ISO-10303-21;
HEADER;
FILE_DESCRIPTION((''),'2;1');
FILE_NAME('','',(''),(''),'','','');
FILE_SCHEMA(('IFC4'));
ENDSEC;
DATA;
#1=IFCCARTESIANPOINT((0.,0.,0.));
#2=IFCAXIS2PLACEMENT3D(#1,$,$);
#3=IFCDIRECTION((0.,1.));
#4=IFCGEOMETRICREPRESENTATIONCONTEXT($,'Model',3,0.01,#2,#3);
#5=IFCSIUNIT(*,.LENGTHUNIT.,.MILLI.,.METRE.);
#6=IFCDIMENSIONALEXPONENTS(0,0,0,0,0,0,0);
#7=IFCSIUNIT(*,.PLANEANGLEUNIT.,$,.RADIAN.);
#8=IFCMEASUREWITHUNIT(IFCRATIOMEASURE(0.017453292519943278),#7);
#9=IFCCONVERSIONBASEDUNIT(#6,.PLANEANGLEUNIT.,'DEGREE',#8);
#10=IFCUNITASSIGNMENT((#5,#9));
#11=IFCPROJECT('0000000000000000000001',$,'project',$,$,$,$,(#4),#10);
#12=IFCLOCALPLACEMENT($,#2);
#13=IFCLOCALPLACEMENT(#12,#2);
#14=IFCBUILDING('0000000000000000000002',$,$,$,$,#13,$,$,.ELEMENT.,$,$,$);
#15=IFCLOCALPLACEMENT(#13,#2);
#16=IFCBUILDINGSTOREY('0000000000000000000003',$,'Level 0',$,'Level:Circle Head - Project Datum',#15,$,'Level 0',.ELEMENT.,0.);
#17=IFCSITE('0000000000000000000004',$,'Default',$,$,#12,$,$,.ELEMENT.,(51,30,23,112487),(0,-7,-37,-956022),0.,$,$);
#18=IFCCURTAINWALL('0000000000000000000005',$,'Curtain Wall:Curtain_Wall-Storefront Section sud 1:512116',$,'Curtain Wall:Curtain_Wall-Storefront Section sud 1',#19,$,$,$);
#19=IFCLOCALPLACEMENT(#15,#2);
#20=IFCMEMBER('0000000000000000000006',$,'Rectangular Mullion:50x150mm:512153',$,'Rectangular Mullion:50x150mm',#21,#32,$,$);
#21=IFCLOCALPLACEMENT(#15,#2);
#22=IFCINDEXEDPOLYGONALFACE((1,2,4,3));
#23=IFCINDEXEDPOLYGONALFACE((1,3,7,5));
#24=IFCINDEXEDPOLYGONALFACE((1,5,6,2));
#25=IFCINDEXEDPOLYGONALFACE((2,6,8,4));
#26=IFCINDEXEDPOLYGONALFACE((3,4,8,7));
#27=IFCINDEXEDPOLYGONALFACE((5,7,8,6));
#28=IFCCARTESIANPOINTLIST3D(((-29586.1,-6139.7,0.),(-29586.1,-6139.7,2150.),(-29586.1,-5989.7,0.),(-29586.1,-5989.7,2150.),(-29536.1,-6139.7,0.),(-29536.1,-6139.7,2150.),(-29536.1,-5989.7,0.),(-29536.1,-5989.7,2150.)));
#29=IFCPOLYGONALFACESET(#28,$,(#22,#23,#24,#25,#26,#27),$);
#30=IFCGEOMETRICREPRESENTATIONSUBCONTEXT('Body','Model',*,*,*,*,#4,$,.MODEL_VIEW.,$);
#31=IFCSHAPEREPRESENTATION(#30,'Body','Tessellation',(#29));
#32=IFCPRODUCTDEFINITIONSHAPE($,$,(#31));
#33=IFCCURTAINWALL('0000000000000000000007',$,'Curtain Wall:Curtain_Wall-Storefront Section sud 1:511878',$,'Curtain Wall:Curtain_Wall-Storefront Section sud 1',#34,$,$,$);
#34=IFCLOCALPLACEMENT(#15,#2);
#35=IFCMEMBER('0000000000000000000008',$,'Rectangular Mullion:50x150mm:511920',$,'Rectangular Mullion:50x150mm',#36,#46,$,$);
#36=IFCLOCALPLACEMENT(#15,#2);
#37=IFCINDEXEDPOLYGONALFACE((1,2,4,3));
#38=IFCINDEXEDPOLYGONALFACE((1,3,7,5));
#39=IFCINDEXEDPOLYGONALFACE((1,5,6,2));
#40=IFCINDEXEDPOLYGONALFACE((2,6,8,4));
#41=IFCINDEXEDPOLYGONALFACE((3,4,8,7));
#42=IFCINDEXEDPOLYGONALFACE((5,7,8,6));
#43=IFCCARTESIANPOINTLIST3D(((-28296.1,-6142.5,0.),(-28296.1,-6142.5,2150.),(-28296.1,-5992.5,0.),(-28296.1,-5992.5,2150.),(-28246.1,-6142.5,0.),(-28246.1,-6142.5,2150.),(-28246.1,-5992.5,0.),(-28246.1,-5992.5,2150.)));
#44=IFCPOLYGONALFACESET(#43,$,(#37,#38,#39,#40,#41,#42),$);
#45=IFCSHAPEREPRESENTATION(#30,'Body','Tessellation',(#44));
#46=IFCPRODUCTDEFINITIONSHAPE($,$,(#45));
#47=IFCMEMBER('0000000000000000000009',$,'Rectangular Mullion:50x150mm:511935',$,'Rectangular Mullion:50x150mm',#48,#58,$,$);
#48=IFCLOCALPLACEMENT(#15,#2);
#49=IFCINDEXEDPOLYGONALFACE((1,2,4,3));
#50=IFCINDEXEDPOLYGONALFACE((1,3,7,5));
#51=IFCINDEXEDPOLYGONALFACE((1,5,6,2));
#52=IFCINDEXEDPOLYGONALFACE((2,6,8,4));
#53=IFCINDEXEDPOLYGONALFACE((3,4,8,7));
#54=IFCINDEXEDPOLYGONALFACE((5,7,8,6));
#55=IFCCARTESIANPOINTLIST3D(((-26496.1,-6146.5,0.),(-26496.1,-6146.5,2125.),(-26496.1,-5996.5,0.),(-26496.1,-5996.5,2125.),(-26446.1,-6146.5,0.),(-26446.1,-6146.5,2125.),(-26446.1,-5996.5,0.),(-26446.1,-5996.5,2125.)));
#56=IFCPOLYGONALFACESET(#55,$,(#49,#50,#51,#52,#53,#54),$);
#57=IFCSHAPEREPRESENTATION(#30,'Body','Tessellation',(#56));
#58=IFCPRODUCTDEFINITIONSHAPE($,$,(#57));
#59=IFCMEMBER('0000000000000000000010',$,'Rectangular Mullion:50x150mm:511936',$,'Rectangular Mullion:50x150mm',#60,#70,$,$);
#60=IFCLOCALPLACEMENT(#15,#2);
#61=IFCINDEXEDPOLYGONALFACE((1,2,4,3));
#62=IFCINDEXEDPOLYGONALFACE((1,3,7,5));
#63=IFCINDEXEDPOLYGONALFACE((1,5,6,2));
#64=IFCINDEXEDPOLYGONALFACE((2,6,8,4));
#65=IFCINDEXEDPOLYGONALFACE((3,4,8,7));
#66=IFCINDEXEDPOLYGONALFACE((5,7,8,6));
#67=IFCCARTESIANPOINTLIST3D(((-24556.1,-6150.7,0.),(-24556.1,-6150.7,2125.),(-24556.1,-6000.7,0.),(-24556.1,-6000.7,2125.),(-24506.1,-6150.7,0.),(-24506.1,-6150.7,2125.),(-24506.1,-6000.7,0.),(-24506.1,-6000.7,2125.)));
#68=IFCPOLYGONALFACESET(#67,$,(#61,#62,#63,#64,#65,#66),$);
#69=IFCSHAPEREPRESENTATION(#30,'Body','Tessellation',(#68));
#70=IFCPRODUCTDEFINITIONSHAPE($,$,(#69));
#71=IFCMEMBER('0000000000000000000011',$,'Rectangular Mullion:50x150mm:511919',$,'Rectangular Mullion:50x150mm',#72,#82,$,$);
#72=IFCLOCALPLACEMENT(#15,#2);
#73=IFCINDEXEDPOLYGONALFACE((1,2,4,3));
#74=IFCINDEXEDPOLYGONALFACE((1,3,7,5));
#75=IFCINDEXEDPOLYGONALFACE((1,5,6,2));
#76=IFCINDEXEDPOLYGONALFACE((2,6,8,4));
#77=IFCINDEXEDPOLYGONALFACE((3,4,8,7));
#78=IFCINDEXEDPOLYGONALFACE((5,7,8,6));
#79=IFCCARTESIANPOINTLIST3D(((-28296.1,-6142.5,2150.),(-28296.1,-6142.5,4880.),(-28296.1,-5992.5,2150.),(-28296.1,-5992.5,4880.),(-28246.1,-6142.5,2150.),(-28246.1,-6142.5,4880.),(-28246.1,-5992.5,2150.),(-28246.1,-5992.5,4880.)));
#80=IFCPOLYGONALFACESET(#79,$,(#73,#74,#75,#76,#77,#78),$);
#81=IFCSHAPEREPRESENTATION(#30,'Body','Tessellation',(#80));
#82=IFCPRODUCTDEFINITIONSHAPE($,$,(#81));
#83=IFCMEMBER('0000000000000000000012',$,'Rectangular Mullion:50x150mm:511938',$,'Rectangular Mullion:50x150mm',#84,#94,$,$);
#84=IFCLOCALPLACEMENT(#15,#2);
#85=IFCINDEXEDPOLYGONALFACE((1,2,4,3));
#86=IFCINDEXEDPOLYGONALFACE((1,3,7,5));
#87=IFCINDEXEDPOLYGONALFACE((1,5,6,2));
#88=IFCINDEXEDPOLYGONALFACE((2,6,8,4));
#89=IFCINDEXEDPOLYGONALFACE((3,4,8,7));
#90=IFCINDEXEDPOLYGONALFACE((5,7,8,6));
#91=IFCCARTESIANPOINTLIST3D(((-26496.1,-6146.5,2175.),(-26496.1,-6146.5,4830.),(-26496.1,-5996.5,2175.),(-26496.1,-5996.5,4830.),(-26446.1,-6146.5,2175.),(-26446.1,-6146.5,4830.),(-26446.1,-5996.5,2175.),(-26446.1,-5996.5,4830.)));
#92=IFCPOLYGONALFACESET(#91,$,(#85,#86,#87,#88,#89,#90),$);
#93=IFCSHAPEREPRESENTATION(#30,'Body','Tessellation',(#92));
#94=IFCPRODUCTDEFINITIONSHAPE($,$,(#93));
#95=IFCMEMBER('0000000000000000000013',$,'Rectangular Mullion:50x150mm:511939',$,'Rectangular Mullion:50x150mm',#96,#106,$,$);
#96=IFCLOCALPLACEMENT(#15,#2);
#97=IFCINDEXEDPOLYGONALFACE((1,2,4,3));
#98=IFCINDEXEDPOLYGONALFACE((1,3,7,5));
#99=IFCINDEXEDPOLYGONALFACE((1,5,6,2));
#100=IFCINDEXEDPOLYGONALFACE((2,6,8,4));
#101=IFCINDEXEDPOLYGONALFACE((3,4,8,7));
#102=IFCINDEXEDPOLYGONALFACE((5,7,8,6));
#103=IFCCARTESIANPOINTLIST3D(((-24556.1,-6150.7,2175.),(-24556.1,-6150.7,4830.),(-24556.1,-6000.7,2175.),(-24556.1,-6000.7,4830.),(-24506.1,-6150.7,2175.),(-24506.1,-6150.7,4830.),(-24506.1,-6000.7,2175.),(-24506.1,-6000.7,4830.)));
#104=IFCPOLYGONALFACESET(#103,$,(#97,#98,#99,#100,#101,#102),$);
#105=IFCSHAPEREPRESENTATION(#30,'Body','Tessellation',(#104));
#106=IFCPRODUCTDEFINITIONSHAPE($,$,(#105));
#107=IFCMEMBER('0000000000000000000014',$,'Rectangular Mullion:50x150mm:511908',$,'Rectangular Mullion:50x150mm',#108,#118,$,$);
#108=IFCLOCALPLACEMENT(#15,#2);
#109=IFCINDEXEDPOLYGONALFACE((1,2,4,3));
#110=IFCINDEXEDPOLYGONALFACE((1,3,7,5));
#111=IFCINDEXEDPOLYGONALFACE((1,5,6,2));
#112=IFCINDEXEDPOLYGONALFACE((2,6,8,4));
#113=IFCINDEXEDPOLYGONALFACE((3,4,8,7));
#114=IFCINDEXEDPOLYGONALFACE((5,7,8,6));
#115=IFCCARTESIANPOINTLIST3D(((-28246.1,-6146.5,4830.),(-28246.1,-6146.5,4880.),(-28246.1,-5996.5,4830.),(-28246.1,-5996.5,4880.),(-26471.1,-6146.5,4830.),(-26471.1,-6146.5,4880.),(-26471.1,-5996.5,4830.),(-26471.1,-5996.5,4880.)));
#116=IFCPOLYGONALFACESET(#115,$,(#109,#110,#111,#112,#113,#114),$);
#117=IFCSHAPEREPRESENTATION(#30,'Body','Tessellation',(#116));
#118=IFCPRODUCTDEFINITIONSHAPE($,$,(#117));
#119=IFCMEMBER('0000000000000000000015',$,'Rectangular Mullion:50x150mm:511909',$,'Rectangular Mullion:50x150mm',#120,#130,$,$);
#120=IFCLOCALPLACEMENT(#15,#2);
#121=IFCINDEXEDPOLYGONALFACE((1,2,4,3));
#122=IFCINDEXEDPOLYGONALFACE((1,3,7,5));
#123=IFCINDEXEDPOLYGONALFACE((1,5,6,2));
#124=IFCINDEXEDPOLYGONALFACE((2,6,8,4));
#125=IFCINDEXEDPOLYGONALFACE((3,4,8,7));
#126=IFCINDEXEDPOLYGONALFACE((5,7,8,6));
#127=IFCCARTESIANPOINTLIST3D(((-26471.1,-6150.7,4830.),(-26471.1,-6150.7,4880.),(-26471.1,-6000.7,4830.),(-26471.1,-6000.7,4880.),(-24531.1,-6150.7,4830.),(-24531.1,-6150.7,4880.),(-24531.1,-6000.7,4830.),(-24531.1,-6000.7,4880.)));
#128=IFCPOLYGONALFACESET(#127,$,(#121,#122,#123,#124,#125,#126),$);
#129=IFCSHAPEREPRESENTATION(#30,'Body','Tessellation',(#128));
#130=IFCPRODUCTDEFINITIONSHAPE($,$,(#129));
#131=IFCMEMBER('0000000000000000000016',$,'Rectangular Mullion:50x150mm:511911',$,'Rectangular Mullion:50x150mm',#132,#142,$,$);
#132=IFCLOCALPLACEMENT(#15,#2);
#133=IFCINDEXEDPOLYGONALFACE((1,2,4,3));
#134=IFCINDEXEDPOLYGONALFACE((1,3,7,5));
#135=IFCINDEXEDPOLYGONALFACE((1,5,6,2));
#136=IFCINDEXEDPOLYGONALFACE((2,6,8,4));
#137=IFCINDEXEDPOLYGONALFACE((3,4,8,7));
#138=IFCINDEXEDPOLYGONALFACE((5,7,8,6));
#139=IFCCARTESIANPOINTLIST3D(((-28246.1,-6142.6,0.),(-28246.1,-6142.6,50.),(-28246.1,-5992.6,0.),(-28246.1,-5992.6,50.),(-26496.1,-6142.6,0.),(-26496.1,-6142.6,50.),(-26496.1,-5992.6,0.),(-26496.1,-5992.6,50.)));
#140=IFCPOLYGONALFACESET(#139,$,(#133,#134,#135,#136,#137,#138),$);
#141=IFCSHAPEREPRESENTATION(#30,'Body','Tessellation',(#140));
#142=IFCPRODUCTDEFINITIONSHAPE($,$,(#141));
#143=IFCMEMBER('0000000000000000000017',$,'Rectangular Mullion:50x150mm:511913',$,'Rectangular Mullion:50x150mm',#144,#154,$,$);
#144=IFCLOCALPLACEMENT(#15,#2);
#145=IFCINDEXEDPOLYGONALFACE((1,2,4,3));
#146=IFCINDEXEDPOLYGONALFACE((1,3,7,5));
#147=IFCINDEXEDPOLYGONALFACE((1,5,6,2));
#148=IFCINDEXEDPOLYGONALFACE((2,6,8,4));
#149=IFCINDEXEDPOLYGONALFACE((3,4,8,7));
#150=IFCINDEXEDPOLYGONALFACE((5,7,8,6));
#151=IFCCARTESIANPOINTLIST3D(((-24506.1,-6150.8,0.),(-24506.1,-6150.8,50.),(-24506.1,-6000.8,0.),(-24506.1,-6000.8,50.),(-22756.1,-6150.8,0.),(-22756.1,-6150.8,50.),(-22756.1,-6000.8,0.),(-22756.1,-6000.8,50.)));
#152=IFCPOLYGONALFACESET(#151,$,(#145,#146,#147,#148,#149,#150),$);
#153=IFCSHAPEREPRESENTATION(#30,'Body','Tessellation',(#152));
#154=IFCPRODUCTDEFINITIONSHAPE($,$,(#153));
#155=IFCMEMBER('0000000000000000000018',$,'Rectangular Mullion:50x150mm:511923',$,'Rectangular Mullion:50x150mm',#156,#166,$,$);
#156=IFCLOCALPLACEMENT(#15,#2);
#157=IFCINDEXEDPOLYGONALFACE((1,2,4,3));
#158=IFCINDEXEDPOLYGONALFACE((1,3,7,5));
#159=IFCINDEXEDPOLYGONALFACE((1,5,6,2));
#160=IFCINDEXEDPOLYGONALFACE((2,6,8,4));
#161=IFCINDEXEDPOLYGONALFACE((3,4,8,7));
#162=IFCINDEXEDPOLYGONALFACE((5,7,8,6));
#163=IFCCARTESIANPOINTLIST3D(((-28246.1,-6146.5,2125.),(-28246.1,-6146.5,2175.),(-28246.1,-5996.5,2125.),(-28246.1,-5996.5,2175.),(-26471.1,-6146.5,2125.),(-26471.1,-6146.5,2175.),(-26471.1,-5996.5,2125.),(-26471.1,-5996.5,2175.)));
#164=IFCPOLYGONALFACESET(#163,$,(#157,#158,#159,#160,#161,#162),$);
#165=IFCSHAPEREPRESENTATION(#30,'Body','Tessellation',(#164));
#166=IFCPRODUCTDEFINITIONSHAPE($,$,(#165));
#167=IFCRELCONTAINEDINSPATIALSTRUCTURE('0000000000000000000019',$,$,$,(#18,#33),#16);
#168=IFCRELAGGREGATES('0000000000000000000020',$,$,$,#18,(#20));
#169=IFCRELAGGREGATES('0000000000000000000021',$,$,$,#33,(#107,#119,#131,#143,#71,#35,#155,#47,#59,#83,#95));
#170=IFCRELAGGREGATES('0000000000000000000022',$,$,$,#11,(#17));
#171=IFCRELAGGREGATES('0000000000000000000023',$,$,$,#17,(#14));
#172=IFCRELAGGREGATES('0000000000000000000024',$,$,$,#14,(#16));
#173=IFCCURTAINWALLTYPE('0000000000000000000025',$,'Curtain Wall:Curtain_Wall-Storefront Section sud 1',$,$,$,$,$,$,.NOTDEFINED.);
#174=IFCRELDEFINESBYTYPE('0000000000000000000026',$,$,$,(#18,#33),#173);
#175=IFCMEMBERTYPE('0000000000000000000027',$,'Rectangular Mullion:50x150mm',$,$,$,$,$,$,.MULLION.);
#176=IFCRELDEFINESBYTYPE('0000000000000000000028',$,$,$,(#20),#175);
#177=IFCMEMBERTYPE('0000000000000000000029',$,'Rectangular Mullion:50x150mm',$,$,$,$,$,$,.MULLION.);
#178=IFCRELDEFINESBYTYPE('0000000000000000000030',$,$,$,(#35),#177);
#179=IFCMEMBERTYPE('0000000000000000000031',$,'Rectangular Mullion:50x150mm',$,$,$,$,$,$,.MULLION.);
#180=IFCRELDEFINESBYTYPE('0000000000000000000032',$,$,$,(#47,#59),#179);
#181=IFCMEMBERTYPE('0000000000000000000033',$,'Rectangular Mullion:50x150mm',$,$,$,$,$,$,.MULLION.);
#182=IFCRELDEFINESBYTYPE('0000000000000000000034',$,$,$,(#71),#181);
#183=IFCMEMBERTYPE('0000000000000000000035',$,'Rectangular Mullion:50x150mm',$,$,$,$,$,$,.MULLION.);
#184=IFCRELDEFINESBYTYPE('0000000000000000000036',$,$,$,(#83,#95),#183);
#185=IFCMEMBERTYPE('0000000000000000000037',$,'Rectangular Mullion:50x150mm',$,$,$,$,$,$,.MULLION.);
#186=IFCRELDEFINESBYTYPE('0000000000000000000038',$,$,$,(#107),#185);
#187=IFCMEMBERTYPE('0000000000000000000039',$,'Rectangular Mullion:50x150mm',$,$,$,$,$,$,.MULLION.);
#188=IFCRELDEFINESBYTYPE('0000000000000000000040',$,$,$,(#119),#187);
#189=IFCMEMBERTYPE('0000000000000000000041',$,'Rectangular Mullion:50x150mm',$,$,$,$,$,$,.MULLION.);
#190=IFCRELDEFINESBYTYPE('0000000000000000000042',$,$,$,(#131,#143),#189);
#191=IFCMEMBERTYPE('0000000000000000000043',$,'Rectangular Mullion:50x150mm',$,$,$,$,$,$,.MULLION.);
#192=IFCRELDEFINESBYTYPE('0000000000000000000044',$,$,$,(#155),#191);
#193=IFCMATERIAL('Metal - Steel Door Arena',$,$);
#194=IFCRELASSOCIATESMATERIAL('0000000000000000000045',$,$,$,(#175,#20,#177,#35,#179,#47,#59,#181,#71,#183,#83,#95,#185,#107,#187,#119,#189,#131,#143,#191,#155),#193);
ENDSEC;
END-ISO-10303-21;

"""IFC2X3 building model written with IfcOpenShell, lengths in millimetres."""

from ifc_helpers import new_model, entity, si_unit, converted_unit, direction, frame, origin, origin_2d_with_axis, place, context, subcontext, project, spatial, rectangle, extrude, source, transform, mapped, material, type_object, type_shapes, element, aggregate, save


model = new_model("IFC2X3")

# Units and contexts
model_context = context("Model", 3, precision=0.01, world=origin(), true_north=direction((0.0, 1.0)))
body_context = subcontext(model_context, "Body", "Model", "MODEL_VIEW")
ifc_project = project(units=[si_unit("LENGTHUNIT", "METRE", prefix="MILLI"), converted_unit("PLANEANGLEUNIT", "DEGREE", entity("IfcRatioMeasure", 0.017453292519943278), si_unit("PLANEANGLEUNIT", "RADIAN"), dimensions=[0, 0, 0, 0, 0, 0, 0])], contexts=[model_context])

# Site, building, storey
site_placement = place(None, origin())
site = spatial("IfcSite", under=ifc_project, at=site_placement, Name="Default", CompositionType="ELEMENT", RefLatitude=(51, 30, 23, 112487), RefLongitude=(0, -7, -37, -956022), RefElevation=0.0)
building_placement = place(site_placement, origin())
building = spatial("IfcBuilding", under=site, at=building_placement, CompositionType="ELEMENT")
storey_placement = place(building_placement, origin())
storey = spatial("IfcBuildingStorey", under=building, at=storey_placement, Name="Level 0", ObjectType="Level:Circle Head - Project Datum", LongName="Level 0", CompositionType="ELEMENT", Elevation=0.0)

# Curtain wall, member
curtain_wall_type = type_object("IfcCurtainWallType", Name="Curtain Wall:Curtain_Wall-Storefront Section sud 1", PredefinedType="NOTDEFINED")
curtain_wall_1_placement = place(storey_placement, origin())
curtain_wall_1 = element("IfcCurtainWall", 1, at=curtain_wall_1_placement, inside=storey, type_object=curtain_wall_type, Name="Curtain Wall:Curtain_Wall-Storefront Section sud 1:512116", ObjectType="Curtain Wall:Curtain_Wall-Storefront Section sud 1")
ifc_material_1 = material(Name="Metal - Steel Door Arena")
member_type_1 = type_object("IfcMemberType", Name="Rectangular Mullion:50x150mm", PredefinedType="MULLION", material=ifc_material_1)
shared_shape_1 = source(origin(), body_context, "Body", "SweptSolid", [
    extrude(rectangle(XDim=150.0, YDim=50.0, at=origin_2d_with_axis()), frame((-25.0, 0.0, -2150.0), z_axis=(0.0, 0.0, 1.0), x_axis=(0.0, -1.0, 0.0)), (0.0, 0.0, 1.0), 2150.0),
])
type_shapes(member_type_1, [shared_shape_1])
member_1_placement = place(curtain_wall_1_placement, frame((-29536.1, -6064.7, 0.0), z_axis=(0.0, 0.0, -1.0), x_axis=(1.0, 0.0, 0.0)))
member_1 = element("IfcMember", 2, at=member_1_placement, type_object=member_type_1, material=ifc_material_1, Name="Rectangular Mullion:50x150mm:512153", ObjectType="Rectangular Mullion:50x150mm", context=body_context, shape_type="MappedRepresentation", body=[
    mapped(shared_shape_1, transform((0.0, 0.0, 0.0), scale=1.0)),
])
aggregate(curtain_wall_1, [member_1])

# Curtain wall, members
curtain_wall_2_placement = place(storey_placement, origin())
curtain_wall_2 = element("IfcCurtainWall", 3, at=curtain_wall_2_placement, inside=storey, type_object=curtain_wall_type, Name="Curtain Wall:Curtain_Wall-Storefront Section sud 1:511878", ObjectType="Curtain Wall:Curtain_Wall-Storefront Section sud 1")
member_type_2 = type_object("IfcMemberType", Name="Rectangular Mullion:50x150mm", PredefinedType="MULLION", material=ifc_material_1)
shared_shape_2 = source(origin(), body_context, "Body", "SweptSolid", [
    extrude(rectangle(XDim=150.0, YDim=50.0, at=origin_2d_with_axis()), frame((-25.0, 0.0, -2150.0), z_axis=(0.0, 0.0, 1.0), x_axis=(0.0, -1.0, 0.0)), (0.0, 0.0, 1.0), 2150.0),
])
type_shapes(member_type_2, [shared_shape_2])
member_2_placement = place(curtain_wall_2_placement, frame((-28296.1, -6067.5, 2150.0), z_axis=(0.0, 0.0, 1.0), x_axis=(-1.0, 0.0, 0.0)))
member_2 = element("IfcMember", 4, at=member_2_placement, type_object=member_type_2, material=ifc_material_1, Name="Rectangular Mullion:50x150mm:511920", ObjectType="Rectangular Mullion:50x150mm", context=body_context, shape_type="MappedRepresentation", body=[
    mapped(shared_shape_2, transform((0.0, 0.0, 0.0), scale=1.0)),
])
member_type_3 = type_object("IfcMemberType", Name="Rectangular Mullion:50x150mm", PredefinedType="MULLION", material=ifc_material_1)
shared_shape_3 = source(origin(), body_context, "Body", "SweptSolid", [
    extrude(rectangle(XDim=150.0, YDim=50.0, at=origin_2d_with_axis()), frame((0.0, 0.0, -2125.0), z_axis=(0.0, 0.0, 1.0), x_axis=(0.0, -1.0, 0.0)), (0.0, 0.0, 1.0), 2125.0),
])
type_shapes(member_type_3, [shared_shape_3])
member_3_placement = place(curtain_wall_2_placement, frame((-26471.1, -6071.5, 0.0), z_axis=(0.0, 0.0, -1.0), x_axis=(1.0, 0.0, 0.0)))
member_3 = element("IfcMember", 5, at=member_3_placement, type_object=member_type_3, material=ifc_material_1, Name="Rectangular Mullion:50x150mm:511935", ObjectType="Rectangular Mullion:50x150mm", context=body_context, shape_type="MappedRepresentation", body=[
    mapped(shared_shape_3, transform((0.0, 0.0, 0.0), scale=1.0)),
])
member_4_placement = place(curtain_wall_2_placement, frame((-24531.1, -6075.7, 0.0), z_axis=(0.0, 0.0, -1.0), x_axis=(1.0, 0.0, 0.0)))
member_4 = element("IfcMember", 6, at=member_4_placement, type_object=member_type_3, material=ifc_material_1, Name="Rectangular Mullion:50x150mm:511936", ObjectType="Rectangular Mullion:50x150mm", context=body_context, shape_type="MappedRepresentation", body=[
    mapped(shared_shape_3, transform((0.0, 0.0, 0.0), scale=1.0)),
])
member_type_4 = type_object("IfcMemberType", Name="Rectangular Mullion:50x150mm", PredefinedType="MULLION", material=ifc_material_1)
shared_shape_4 = source(origin(), body_context, "Body", "SweptSolid", [
    extrude(rectangle(XDim=150.0, YDim=50.0, at=origin_2d_with_axis()), frame((-25.0, 0.0, -2730.0), z_axis=(0.0, 0.0, 1.0), x_axis=(0.0, -1.0, 0.0)), (0.0, 0.0, 1.0), 2730.0),
])
type_shapes(member_type_4, [shared_shape_4])
member_5_placement = place(curtain_wall_2_placement, frame((-28296.1, -6067.5, 4880.0), z_axis=(0.0, 0.0, 1.0), x_axis=(-1.0, 0.0, 0.0)))
member_5 = element("IfcMember", 7, at=member_5_placement, type_object=member_type_4, material=ifc_material_1, Name="Rectangular Mullion:50x150mm:511919", ObjectType="Rectangular Mullion:50x150mm", context=body_context, shape_type="MappedRepresentation", body=[
    mapped(shared_shape_4, transform((0.0, 0.0, 0.0), scale=1.0)),
])
member_type_5 = type_object("IfcMemberType", Name="Rectangular Mullion:50x150mm", PredefinedType="MULLION", material=ifc_material_1)
shared_shape_5 = source(origin(), body_context, "Body", "SweptSolid", [
    extrude(rectangle(XDim=150.0, YDim=50.0, at=origin_2d_with_axis()), frame((0.0, 0.0, -2655.0), z_axis=(0.0, 0.0, 1.0), x_axis=(0.0, -1.0, 0.0)), (0.0, 0.0, 1.0), 2655.0),
])
type_shapes(member_type_5, [shared_shape_5])
member_6_placement = place(curtain_wall_2_placement, frame((-26471.1, -6071.5, 2175.0), z_axis=(0.0, 0.0, -1.0), x_axis=(1.0, 0.0, 0.0)))
member_6 = element("IfcMember", 8, at=member_6_placement, type_object=member_type_5, material=ifc_material_1, Name="Rectangular Mullion:50x150mm:511938", ObjectType="Rectangular Mullion:50x150mm", context=body_context, shape_type="MappedRepresentation", body=[
    mapped(shared_shape_5, transform((0.0, 0.0, 0.0), scale=1.0)),
])
member_7_placement = place(curtain_wall_2_placement, frame((-24531.1, -6075.7, 2175.0), z_axis=(0.0, 0.0, -1.0), x_axis=(1.0, 0.0, 0.0)))
member_7 = element("IfcMember", 9, at=member_7_placement, type_object=member_type_5, material=ifc_material_1, Name="Rectangular Mullion:50x150mm:511939", ObjectType="Rectangular Mullion:50x150mm", context=body_context, shape_type="MappedRepresentation", body=[
    mapped(shared_shape_5, transform((0.0, 0.0, 0.0), scale=1.0)),
])
member_type_6 = type_object("IfcMemberType", Name="Rectangular Mullion:50x150mm", PredefinedType="MULLION", material=ifc_material_1)
shared_shape_6 = source(origin(), body_context, "Body", "SweptSolid", [
    extrude(rectangle(XDim=150.0, YDim=50.0, at=origin_2d_with_axis()), frame((-25.0, 0.0, -1775.0), z_axis=(0.0, 0.0, 1.0), x_axis=(0.0, -1.0, 0.0)), (0.0, 0.0, 1.0), 1775.0),
])
type_shapes(member_type_6, [shared_shape_6])
member_8_placement = place(curtain_wall_2_placement, frame((-26471.1, -6071.5, 4880.0), z_axis=(1.0, 0.0, 0.0), x_axis=(0.0, 0.0, 1.0)))
member_8 = element("IfcMember", 10, at=member_8_placement, type_object=member_type_6, material=ifc_material_1, Name="Rectangular Mullion:50x150mm:511908", ObjectType="Rectangular Mullion:50x150mm", context=body_context, shape_type="MappedRepresentation", body=[
    mapped(shared_shape_6, transform((0.0, 0.0, 0.0), scale=1.0)),
])
member_type_7 = type_object("IfcMemberType", Name="Rectangular Mullion:50x150mm", PredefinedType="MULLION", material=ifc_material_1)
shared_shape_7 = source(origin(), body_context, "Body", "SweptSolid", [
    extrude(rectangle(XDim=150.0, YDim=50.0, at=origin_2d_with_axis()), frame((-25.0, 0.0, -1940.0), z_axis=(0.0, 0.0, 1.0), x_axis=(0.0, -1.0, 0.0)), (0.0, 0.0, 1.0), 1940.0),
])
type_shapes(member_type_7, [shared_shape_7])
member_9_placement = place(curtain_wall_2_placement, frame((-24531.1, -6075.7, 4880.0), z_axis=(1.0, 0.0, 0.0), x_axis=(0.0, 0.0, 1.0)))
member_9 = element("IfcMember", 11, at=member_9_placement, type_object=member_type_7, material=ifc_material_1, Name="Rectangular Mullion:50x150mm:511909", ObjectType="Rectangular Mullion:50x150mm", context=body_context, shape_type="MappedRepresentation", body=[
    mapped(shared_shape_7, transform((0.0, 0.0, 0.0), scale=1.0)),
])
member_type_8 = type_object("IfcMemberType", Name="Rectangular Mullion:50x150mm", PredefinedType="MULLION", material=ifc_material_1)
shared_shape_8 = source(origin(), body_context, "Body", "SweptSolid", [
    extrude(rectangle(XDim=150.0, YDim=50.0, at=origin_2d_with_axis()), frame((-25.0, 0.0, -1750.0), z_axis=(0.0, 0.0, 1.0), x_axis=(0.0, -1.0, 0.0)), (0.0, 0.0, 1.0), 1750.0),
])
type_shapes(member_type_8, [shared_shape_8])
member_10_placement = place(curtain_wall_2_placement, frame((-28246.1, -6067.6, 0.0), z_axis=(-1.0, 0.0, 0.0), x_axis=(0.0, 0.0, -1.0)))
member_10 = element("IfcMember", 12, at=member_10_placement, type_object=member_type_8, material=ifc_material_1, Name="Rectangular Mullion:50x150mm:511911", ObjectType="Rectangular Mullion:50x150mm", context=body_context, shape_type="MappedRepresentation", body=[
    mapped(shared_shape_8, transform((0.0, 0.0, 0.0), scale=1.0)),
])
member_11_placement = place(curtain_wall_2_placement, frame((-24506.1, -6075.8, 0.0), z_axis=(-1.0, 0.0, 0.0), x_axis=(0.0, 0.0, -1.0)))
member_11 = element("IfcMember", 13, at=member_11_placement, type_object=member_type_8, material=ifc_material_1, Name="Rectangular Mullion:50x150mm:511913", ObjectType="Rectangular Mullion:50x150mm", context=body_context, shape_type="MappedRepresentation", body=[
    mapped(shared_shape_8, transform((0.0, 0.0, 0.0), scale=1.0)),
])
member_type_9 = type_object("IfcMemberType", Name="Rectangular Mullion:50x150mm", PredefinedType="MULLION", material=ifc_material_1)
shared_shape_9 = source(origin(), body_context, "Body", "SweptSolid", [
    extrude(rectangle(XDim=150.0, YDim=50.0, at=origin_2d_with_axis()), frame((0.0, 0.0, -1775.0), z_axis=(0.0, 0.0, 1.0), x_axis=(0.0, -1.0, 0.0)), (0.0, 0.0, 1.0), 1775.0),
])
type_shapes(member_type_9, [shared_shape_9])
member_12_placement = place(curtain_wall_2_placement, frame((-26471.1, -6071.5, 2150.0), z_axis=(1.0, 0.0, 0.0), x_axis=(0.0, 0.0, 1.0)))
member_12 = element("IfcMember", 14, at=member_12_placement, type_object=member_type_9, material=ifc_material_1, Name="Rectangular Mullion:50x150mm:511923", ObjectType="Rectangular Mullion:50x150mm", context=body_context, shape_type="MappedRepresentation", body=[
    mapped(shared_shape_9, transform((0.0, 0.0, 0.0), scale=1.0)),
])
aggregate(curtain_wall_2, [member_8, member_9, member_10, member_11, member_5, member_2, member_12, member_3, member_4, member_6, member_7])

save(model, "model.ifc")
